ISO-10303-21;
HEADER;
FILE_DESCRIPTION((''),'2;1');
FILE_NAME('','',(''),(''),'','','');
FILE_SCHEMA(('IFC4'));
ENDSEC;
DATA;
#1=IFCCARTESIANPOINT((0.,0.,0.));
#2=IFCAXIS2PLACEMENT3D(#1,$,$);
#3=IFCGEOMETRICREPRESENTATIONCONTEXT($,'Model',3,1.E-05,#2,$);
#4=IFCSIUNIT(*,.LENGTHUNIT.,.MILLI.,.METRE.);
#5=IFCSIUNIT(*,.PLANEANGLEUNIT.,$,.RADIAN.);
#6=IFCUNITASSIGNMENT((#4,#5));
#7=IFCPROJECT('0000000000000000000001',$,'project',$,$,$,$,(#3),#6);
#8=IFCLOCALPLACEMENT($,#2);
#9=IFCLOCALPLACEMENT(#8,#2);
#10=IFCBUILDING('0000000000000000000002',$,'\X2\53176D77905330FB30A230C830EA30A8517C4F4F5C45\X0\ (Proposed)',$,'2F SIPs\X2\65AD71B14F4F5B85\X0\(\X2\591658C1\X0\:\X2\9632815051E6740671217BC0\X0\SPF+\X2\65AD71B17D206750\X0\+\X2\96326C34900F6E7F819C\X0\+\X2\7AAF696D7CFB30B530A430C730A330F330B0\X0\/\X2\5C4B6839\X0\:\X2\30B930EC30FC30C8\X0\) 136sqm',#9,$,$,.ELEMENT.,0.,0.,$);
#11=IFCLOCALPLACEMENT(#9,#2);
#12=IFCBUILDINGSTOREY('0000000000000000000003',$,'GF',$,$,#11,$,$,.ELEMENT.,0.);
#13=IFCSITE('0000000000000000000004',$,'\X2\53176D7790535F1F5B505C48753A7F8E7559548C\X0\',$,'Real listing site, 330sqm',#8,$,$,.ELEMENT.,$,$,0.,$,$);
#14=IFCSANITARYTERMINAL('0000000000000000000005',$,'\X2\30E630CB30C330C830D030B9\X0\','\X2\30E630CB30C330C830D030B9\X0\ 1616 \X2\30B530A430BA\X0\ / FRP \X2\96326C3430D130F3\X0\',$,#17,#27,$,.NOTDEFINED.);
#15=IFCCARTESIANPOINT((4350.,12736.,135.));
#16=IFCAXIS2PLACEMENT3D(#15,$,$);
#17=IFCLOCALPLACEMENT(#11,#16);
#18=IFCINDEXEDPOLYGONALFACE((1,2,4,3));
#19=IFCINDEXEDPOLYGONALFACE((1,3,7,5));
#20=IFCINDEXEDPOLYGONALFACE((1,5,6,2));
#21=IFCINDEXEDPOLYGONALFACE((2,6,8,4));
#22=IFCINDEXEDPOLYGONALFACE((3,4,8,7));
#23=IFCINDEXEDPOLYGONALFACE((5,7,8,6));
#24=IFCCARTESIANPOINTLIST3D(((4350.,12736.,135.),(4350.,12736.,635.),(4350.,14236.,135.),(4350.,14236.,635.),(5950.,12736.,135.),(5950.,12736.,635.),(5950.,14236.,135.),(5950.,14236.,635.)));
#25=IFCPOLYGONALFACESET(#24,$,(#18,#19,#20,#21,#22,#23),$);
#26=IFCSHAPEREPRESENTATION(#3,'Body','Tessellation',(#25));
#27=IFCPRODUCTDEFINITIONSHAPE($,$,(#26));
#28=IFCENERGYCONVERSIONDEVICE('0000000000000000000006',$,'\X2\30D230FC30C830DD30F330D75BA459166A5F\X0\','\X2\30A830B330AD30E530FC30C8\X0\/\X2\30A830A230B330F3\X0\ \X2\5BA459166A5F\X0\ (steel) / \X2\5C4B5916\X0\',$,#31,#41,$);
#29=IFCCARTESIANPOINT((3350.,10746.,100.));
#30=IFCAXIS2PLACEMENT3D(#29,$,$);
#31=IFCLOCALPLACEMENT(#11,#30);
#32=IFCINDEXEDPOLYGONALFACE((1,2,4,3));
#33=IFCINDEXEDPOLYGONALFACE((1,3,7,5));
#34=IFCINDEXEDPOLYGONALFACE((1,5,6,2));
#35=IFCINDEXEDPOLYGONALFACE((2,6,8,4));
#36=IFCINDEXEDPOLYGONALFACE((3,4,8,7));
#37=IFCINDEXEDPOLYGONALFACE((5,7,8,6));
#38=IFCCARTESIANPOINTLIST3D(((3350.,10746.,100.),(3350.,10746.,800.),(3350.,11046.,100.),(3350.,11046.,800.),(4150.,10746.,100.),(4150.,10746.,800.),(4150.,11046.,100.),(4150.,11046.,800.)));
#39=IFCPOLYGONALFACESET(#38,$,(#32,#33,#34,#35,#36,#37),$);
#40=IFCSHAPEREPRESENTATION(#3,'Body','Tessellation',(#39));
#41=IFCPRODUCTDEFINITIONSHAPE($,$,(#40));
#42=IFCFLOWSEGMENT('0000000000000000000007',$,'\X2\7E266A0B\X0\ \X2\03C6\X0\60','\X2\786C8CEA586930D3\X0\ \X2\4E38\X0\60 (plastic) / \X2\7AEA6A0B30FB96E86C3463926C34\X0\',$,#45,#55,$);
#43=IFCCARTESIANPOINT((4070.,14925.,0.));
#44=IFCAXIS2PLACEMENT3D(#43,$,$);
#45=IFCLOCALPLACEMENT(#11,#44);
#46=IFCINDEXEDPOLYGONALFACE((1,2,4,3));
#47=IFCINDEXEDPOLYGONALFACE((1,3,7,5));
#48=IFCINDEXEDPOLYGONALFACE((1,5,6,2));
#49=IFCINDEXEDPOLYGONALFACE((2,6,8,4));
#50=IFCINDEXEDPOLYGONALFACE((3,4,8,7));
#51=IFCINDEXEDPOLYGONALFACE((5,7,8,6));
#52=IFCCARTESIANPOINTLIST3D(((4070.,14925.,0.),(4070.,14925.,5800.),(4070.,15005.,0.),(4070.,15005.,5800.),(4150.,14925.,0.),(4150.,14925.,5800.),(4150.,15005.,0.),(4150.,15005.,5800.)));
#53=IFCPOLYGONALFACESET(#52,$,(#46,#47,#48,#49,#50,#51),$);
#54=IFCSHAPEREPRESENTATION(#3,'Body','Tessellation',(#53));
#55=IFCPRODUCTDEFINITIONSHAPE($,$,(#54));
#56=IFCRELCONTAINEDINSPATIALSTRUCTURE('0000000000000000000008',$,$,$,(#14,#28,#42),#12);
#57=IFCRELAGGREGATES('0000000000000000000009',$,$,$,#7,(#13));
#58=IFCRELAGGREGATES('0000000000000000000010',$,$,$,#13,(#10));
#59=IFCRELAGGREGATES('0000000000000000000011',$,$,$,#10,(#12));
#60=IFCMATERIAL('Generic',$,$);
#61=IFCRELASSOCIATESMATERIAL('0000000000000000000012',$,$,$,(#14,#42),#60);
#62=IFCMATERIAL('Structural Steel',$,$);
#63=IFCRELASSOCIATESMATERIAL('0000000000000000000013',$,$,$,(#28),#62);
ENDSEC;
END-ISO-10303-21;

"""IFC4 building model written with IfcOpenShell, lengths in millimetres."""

from ifc_helpers import new_model, si_unit, frame, frame_2d, origin, place, context, project, spatial, rectangle, extrude, material, element, save


model = new_model("IFC4")

# Units and contexts
model_context = context("Model", 3, precision=1e-05, world=origin())
ifc_project = project(units=[si_unit("LENGTHUNIT", "METRE", prefix="MILLI"), si_unit("PLANEANGLEUNIT", "RADIAN")], contexts=[model_context])

# Site, building, storey
site_placement = place(None, origin())
site = spatial("IfcSite", under=ifc_project, at=site_placement, Name="北海道弟子屈町美留和", ObjectType="Real listing site, 330sqm", CompositionType="ELEMENT", RefElevation=0.0)
building_placement = place(site_placement, origin())
building = spatial("IfcBuilding", under=site, at=building_placement, Name="北海道・アトリエ兼住居 (Proposed)", ObjectType="2F SIPs断熱住宅(外壁:防腐処理無節SPF+断熱素材+防水透湿膜+窯業系サイディング/屋根:スレート) 136sqm", CompositionType="ELEMENT", ElevationOfRefHeight=0.0, ElevationOfTerrain=0.0)
storey_placement = place(building_placement, origin())
storey = spatial("IfcBuildingStorey", under=building, at=storey_placement, Name="GF", CompositionType="ELEMENT", Elevation=0.0)

# Shared definitions
ifc_material_1 = material(Name="Generic")

# Sanitary terminal
sanitary_terminal_placement = place(storey_placement, frame((4350.0, 12736.0, 135.0)))
element("IfcSanitaryTerminal", 1, at=sanitary_terminal_placement, inside=storey, material=ifc_material_1, Name="ユニットバス", Description="ユニットバス 1616 サイズ / FRP 防水パン", PredefinedType="NOTDEFINED", context=model_context, shape_type="SweptSolid", body=[
    extrude(rectangle(XDim=1600.0, YDim=1500.0, at=frame_2d((800.0, 750.0))), frame((4350.0, 12736.0, 135.0)), (0.0, 0.0, 1.0), 500.0),
])

# Energy conversion device
ifc_material_2 = material(Name="Structural Steel")
energy_conversion_device_placement = place(storey_placement, frame((3350.0, 10746.0, 100.0)))
element("IfcEnergyConversionDevice", 2, at=energy_conversion_device_placement, inside=storey, material=ifc_material_2, Name="ヒートポンプ室外機", Description="エコキュート/エアコン 室外機 (steel) / 屋外", context=model_context, shape_type="SweptSolid", body=[
    extrude(rectangle(XDim=800.0, YDim=300.0, at=frame_2d((400.0, 150.0))), frame((3350.0, 10746.0, 100.0)), (0.0, 0.0, 1.0), 700.0),
])

# Flow segment
flow_segment_placement = place(storey_placement, frame((4070.0, 14925.0, 0.0)))
element("IfcFlowSegment", 3, at=flow_segment_placement, inside=storey, material=ifc_material_1, Name="縦樋 φ60", Description="硬質塩ビ 丸60 (plastic) / 竪樋・雨水排水", context=model_context, shape_type="SweptSolid", body=[
    extrude(rectangle(XDim=80.0, YDim=80.0, at=frame_2d((40.0, 40.0))), frame((4070.0, 14925.0, 0.0)), (0.0, 0.0, 1.0), 5800.0),
])

save(model, "model.ifc")
